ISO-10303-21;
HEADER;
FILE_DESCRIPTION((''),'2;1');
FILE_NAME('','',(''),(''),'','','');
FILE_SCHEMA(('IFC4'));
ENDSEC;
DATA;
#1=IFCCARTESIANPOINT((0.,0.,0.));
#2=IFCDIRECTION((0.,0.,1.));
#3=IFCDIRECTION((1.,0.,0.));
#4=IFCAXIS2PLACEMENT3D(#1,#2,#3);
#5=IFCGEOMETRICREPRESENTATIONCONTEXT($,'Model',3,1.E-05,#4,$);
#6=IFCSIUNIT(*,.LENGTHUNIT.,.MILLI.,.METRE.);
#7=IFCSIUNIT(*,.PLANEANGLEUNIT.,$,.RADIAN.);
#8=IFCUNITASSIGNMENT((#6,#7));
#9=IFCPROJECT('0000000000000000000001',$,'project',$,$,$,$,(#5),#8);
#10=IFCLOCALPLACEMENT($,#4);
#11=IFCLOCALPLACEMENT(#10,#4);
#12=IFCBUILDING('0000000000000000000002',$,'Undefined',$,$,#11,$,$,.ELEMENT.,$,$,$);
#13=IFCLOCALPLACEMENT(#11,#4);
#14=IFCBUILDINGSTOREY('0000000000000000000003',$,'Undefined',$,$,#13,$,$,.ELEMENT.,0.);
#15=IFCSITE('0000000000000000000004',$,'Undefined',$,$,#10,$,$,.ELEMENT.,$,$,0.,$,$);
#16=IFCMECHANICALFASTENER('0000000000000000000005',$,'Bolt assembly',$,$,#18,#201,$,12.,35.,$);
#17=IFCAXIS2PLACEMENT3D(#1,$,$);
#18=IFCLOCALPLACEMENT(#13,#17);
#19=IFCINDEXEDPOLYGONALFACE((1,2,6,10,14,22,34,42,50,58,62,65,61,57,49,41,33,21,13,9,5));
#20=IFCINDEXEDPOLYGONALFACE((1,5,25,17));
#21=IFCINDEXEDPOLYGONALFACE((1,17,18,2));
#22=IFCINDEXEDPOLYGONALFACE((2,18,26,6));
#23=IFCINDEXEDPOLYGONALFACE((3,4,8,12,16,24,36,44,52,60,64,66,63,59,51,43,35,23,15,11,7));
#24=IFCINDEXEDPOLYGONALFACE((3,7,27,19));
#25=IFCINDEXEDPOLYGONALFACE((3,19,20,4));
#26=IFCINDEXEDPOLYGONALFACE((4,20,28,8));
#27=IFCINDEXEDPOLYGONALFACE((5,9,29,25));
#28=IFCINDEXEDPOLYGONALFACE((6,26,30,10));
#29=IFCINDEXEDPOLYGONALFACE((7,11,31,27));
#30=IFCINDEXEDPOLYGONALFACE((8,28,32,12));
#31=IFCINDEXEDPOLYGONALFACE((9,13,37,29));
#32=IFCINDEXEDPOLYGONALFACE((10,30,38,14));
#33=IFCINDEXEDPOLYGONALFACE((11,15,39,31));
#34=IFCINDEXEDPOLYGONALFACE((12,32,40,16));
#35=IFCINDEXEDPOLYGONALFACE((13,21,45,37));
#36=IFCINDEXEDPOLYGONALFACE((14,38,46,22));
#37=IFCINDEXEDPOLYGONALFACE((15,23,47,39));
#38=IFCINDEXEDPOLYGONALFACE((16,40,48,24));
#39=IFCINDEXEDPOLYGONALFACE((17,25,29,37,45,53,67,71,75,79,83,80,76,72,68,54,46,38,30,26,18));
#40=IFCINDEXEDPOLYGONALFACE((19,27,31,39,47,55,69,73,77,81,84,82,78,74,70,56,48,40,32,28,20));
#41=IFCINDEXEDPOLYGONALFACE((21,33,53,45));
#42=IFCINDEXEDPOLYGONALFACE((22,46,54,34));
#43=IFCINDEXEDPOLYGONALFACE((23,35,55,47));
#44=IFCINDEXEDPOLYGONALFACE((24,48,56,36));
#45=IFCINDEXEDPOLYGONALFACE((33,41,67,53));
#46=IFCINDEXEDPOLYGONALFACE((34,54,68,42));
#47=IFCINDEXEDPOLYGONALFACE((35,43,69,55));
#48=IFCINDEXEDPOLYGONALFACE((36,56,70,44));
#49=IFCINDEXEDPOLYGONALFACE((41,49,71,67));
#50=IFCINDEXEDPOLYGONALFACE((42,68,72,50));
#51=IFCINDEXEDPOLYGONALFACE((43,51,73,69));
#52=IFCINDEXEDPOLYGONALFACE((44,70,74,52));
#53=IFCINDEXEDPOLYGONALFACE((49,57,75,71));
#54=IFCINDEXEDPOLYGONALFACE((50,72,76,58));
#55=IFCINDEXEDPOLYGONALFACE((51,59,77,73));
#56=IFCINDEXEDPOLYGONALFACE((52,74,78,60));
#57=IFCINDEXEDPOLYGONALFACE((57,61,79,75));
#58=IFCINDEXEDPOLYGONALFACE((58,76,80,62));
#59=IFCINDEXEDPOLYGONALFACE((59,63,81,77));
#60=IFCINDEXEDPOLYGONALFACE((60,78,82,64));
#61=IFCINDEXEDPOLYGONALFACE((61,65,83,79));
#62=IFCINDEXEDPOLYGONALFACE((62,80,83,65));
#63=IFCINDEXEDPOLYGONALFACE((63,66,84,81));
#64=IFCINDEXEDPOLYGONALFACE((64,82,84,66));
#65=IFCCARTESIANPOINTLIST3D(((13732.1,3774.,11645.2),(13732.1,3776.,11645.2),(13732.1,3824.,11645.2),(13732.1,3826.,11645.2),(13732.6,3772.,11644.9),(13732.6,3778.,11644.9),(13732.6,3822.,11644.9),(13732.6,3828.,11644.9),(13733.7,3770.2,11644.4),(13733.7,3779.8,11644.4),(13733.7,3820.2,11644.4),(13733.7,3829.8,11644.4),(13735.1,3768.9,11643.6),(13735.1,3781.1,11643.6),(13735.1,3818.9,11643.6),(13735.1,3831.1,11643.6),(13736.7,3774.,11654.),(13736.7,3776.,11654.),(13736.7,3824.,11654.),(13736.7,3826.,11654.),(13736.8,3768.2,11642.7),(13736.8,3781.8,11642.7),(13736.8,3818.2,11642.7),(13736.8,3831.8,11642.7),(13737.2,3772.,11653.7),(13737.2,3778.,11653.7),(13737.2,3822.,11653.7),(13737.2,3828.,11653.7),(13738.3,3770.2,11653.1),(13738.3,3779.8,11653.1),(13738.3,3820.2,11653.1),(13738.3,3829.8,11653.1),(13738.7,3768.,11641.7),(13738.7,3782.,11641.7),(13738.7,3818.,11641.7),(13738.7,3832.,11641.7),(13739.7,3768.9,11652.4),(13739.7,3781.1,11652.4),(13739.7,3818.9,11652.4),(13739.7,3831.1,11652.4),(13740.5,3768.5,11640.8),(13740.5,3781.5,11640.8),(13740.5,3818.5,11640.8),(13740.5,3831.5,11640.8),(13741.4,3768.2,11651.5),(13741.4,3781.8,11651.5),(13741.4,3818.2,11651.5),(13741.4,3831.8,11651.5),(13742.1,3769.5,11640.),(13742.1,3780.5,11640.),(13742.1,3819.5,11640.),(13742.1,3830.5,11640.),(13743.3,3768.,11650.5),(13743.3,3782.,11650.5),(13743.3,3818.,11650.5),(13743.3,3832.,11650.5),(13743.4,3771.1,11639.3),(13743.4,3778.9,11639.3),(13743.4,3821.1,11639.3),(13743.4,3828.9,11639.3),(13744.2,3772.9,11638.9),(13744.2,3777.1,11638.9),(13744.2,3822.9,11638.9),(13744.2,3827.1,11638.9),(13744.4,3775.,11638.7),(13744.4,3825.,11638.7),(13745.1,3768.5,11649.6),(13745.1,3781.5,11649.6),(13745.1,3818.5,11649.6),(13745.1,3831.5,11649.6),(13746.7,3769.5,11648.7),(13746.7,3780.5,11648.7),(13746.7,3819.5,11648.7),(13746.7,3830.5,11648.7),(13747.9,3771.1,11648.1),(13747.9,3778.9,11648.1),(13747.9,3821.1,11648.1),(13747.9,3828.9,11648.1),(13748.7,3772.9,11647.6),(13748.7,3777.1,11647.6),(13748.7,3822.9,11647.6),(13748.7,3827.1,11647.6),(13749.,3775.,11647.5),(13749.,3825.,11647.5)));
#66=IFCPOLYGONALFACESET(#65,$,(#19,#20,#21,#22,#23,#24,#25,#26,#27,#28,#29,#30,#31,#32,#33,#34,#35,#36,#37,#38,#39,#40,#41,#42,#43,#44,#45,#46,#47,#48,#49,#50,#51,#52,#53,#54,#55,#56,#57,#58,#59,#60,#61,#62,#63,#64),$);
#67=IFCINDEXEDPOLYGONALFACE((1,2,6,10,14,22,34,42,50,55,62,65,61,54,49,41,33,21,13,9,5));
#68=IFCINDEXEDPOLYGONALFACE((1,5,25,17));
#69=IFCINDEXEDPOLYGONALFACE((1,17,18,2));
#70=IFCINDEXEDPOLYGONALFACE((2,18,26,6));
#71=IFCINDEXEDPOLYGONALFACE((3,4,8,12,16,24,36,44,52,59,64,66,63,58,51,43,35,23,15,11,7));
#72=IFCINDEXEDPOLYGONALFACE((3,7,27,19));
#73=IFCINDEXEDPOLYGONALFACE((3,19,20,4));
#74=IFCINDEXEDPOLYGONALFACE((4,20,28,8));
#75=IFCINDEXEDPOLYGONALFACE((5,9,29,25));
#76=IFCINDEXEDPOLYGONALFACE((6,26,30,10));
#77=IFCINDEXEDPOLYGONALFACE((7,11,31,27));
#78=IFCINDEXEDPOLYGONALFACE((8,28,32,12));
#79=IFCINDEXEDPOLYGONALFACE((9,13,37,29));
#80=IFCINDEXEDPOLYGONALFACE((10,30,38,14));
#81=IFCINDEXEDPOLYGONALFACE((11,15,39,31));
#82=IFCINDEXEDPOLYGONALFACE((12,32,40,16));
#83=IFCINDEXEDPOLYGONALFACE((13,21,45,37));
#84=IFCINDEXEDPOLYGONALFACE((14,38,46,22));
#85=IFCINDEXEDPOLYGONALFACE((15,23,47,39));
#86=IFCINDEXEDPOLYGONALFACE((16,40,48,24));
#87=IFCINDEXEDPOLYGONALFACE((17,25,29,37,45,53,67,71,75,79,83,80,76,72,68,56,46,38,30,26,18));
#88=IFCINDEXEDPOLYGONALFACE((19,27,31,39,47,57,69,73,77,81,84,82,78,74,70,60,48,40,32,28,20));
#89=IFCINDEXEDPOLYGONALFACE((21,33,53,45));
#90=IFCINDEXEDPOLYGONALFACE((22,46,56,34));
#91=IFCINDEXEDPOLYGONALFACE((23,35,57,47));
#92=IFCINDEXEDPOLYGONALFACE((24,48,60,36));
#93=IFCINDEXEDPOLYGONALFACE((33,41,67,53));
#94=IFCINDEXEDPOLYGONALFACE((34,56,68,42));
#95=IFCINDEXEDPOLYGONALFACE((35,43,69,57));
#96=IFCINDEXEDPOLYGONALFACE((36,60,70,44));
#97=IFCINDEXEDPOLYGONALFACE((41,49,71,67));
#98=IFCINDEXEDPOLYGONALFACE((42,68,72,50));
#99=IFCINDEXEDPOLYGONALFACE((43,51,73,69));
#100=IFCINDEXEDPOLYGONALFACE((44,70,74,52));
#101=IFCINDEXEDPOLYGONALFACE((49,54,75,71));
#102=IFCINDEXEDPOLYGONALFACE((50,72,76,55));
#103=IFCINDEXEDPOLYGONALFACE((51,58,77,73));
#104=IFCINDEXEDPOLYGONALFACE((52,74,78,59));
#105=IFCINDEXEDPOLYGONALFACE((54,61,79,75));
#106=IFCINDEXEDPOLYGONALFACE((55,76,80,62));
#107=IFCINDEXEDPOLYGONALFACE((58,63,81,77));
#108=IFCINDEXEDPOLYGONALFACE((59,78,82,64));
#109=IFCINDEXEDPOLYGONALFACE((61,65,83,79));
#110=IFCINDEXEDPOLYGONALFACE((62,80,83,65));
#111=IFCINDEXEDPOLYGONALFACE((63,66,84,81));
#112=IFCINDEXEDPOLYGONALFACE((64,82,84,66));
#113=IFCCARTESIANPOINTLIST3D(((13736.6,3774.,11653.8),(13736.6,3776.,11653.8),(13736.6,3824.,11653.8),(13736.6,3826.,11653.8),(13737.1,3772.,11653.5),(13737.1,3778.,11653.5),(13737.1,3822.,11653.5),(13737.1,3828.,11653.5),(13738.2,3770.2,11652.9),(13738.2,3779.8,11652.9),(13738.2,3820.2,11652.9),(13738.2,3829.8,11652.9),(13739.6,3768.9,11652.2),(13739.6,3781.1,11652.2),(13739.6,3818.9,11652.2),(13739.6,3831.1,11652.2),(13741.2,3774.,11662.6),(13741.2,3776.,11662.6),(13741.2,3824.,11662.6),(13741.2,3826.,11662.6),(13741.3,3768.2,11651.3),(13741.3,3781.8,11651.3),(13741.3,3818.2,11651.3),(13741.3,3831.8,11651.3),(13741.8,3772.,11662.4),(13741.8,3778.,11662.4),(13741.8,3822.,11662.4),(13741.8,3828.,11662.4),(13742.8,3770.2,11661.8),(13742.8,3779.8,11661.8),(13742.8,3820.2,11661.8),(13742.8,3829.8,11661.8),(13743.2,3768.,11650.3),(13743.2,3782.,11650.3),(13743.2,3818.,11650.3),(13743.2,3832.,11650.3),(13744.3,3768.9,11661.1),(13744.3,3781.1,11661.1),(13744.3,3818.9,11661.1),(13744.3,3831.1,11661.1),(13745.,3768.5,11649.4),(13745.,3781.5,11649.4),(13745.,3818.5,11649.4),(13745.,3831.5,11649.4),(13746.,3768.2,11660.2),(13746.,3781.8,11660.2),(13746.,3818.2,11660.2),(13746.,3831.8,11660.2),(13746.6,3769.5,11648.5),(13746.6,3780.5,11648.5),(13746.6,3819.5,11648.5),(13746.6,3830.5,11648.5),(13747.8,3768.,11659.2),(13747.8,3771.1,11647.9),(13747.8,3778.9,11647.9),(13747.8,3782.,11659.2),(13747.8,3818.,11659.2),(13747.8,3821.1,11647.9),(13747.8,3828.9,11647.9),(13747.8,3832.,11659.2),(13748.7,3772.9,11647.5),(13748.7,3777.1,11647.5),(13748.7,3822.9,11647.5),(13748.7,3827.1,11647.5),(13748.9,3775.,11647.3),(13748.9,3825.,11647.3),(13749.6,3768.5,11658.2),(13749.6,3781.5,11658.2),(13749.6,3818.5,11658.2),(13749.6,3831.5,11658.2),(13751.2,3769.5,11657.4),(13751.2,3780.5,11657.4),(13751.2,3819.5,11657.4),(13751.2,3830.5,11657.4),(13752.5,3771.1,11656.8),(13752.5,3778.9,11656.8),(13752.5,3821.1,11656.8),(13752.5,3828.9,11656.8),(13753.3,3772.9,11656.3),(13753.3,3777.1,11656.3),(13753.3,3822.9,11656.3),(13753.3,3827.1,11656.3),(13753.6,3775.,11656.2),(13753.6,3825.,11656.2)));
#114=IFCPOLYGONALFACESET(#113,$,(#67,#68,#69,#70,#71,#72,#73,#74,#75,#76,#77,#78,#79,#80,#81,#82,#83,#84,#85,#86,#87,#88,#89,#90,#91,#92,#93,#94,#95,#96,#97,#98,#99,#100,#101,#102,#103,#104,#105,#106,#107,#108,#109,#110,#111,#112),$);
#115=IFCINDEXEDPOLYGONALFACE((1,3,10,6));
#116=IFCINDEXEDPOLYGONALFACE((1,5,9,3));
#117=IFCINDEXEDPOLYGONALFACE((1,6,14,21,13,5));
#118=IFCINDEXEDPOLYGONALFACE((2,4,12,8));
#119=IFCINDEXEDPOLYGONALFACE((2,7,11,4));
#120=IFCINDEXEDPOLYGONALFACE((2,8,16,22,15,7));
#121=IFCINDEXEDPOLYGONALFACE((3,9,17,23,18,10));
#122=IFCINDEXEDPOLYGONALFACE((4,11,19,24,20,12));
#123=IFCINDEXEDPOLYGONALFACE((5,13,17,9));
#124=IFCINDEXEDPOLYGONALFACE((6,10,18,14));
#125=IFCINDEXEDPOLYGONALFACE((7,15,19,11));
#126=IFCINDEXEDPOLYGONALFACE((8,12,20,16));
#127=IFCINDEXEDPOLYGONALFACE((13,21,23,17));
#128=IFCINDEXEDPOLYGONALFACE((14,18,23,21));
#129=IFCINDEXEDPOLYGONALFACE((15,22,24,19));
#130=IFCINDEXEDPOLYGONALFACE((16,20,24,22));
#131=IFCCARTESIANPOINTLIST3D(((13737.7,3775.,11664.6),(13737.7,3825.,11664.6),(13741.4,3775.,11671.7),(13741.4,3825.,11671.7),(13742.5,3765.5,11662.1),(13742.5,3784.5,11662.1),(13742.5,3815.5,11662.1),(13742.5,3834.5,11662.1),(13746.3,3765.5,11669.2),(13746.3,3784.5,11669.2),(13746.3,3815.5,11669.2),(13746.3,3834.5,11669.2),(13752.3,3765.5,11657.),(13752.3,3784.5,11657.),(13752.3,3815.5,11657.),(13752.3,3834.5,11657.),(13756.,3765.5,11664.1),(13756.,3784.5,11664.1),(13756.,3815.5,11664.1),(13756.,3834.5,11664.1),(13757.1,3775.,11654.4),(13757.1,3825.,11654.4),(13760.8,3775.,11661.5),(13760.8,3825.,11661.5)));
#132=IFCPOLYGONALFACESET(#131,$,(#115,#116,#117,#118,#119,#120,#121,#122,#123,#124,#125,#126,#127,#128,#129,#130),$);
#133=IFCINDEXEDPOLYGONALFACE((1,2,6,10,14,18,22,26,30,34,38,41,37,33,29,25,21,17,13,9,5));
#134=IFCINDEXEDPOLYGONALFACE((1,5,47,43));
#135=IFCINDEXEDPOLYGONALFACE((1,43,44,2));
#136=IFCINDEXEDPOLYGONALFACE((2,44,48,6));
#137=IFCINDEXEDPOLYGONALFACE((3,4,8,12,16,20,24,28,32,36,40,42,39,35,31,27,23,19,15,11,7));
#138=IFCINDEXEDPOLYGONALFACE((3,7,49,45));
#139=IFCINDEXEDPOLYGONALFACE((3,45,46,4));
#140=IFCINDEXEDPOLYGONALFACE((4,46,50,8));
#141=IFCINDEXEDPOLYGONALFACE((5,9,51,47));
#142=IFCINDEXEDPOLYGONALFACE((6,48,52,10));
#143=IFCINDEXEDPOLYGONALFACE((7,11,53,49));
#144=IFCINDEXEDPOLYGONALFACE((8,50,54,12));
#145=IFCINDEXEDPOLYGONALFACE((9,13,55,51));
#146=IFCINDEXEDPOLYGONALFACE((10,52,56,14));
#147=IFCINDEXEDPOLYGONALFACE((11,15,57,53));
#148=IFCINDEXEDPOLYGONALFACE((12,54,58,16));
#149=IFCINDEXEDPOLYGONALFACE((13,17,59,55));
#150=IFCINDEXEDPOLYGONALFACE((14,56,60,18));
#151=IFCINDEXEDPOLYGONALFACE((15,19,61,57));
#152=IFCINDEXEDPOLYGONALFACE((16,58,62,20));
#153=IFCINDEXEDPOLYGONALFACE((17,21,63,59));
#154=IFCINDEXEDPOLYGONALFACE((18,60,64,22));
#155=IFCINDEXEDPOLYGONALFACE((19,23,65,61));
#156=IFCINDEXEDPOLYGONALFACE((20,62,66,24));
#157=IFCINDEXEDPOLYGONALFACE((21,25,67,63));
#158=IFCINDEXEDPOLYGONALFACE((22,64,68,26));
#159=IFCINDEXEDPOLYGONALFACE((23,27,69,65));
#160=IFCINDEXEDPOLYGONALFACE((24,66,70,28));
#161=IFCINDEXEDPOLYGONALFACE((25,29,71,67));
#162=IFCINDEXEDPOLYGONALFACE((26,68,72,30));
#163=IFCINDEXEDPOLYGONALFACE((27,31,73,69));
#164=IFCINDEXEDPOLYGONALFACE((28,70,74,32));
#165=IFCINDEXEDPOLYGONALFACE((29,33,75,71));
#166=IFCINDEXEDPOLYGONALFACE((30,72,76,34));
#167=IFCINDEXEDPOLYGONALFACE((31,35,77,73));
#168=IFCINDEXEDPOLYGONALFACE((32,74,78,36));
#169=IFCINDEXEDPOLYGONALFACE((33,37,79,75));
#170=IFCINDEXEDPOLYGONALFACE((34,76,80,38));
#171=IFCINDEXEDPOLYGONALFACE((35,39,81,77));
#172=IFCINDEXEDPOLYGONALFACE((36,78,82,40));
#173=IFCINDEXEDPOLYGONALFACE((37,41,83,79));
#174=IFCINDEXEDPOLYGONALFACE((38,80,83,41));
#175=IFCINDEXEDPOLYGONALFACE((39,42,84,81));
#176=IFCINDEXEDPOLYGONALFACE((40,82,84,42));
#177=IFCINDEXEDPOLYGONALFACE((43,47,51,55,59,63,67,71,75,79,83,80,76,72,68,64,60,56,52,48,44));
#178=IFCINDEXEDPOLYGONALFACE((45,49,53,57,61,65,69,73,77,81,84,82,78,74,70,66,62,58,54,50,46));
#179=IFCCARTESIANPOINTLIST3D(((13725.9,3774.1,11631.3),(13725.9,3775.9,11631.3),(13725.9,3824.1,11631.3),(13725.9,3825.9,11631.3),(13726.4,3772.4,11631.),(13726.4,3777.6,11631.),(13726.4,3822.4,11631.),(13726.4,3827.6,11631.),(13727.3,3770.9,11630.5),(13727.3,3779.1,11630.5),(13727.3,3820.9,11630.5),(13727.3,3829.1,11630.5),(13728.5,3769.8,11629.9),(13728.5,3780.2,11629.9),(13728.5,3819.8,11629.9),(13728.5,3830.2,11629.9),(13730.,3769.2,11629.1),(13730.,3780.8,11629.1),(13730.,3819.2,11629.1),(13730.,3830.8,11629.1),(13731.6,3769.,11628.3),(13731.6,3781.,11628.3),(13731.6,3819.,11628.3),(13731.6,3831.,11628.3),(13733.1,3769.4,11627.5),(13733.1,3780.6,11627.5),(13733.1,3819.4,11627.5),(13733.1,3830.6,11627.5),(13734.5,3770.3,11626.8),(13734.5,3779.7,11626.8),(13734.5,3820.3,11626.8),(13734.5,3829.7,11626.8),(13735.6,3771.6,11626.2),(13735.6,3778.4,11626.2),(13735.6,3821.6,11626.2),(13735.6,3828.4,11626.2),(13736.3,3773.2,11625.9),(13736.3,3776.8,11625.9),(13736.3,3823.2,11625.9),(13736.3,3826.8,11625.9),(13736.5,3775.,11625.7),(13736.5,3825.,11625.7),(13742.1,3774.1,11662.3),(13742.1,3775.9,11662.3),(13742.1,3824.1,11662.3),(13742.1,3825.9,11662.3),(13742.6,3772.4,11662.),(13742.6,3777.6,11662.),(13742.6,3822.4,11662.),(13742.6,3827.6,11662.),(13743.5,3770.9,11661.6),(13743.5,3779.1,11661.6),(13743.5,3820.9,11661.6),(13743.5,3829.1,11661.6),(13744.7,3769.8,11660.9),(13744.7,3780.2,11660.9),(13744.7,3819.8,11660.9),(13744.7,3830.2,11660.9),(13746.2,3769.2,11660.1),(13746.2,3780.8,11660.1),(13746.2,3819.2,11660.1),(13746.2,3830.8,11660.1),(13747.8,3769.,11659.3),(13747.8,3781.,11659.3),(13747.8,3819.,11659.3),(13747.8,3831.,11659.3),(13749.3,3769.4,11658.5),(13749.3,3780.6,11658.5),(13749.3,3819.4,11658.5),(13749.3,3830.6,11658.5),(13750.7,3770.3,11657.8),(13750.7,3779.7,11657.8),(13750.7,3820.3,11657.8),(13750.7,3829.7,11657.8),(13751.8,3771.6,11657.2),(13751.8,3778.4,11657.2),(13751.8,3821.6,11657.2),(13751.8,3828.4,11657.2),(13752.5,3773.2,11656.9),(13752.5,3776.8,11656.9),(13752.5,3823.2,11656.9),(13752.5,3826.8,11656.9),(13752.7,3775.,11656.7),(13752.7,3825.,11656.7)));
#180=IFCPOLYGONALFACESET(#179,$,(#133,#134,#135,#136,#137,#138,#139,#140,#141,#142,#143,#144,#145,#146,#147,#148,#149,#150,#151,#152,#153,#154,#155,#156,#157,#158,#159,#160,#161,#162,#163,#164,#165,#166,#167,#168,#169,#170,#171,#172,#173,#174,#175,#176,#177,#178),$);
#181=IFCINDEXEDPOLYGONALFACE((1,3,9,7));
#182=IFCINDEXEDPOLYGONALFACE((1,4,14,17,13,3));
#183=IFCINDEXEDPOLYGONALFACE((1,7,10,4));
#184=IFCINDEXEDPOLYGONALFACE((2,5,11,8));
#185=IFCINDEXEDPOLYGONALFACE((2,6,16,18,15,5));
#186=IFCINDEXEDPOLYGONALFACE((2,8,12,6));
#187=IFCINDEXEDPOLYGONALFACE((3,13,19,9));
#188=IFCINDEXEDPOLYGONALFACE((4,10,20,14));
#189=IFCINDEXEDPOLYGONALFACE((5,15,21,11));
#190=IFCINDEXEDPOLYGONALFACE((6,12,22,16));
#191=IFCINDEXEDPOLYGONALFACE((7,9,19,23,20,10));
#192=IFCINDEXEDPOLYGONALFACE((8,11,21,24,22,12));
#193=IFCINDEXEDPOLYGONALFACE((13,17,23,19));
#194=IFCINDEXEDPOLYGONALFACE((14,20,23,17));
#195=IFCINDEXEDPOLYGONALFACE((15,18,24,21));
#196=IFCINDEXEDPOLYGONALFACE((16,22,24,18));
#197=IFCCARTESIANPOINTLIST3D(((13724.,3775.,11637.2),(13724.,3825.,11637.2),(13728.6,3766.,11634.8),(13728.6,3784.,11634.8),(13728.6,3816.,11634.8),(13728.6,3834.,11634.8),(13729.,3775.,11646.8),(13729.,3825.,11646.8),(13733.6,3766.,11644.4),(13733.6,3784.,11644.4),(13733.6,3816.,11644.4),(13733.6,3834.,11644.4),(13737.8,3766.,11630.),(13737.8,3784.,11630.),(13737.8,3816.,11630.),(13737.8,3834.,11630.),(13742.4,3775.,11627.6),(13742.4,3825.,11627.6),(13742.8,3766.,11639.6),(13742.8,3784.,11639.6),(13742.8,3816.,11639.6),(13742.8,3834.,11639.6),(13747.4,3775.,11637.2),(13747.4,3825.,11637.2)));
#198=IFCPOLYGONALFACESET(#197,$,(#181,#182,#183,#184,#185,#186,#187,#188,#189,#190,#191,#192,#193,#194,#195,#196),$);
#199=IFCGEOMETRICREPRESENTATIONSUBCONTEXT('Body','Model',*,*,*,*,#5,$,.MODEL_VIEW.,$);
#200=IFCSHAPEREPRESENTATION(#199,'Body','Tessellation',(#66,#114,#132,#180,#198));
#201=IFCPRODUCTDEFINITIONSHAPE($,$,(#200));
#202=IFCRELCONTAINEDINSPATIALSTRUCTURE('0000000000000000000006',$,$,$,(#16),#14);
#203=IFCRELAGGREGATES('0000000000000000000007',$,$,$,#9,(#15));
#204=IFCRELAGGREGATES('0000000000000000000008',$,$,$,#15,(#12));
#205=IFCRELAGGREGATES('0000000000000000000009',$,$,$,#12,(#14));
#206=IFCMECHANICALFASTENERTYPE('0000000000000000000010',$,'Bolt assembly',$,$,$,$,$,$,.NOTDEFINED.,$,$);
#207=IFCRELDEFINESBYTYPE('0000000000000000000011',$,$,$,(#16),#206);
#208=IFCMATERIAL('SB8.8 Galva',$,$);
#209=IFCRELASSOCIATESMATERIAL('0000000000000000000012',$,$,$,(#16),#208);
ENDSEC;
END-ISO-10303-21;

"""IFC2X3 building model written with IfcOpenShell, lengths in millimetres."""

from ifc_helpers import new_model, si_unit, frame, origin_with_axes, origin_2d_with_axis, place, context, subcontext, project, spatial, polyline, circle, outline, extrude, source, transform, mapped, material, type_object, element, save


model = new_model("IFC2X3")

# Units and contexts
model_context = context("Model", 3, precision=1e-05, world=origin_with_axes())
body_context = subcontext(model_context, "Body", "Model", "MODEL_VIEW")
ifc_project = project(units=[si_unit("LENGTHUNIT", "METRE", prefix="MILLI"), si_unit("PLANEANGLEUNIT", "RADIAN")], contexts=[model_context])

# Site, building, storey
site_placement = place(None, origin_with_axes())
site = spatial("IfcSite", under=ifc_project, at=site_placement, Name="Undefined", CompositionType="ELEMENT", RefElevation=0.0)
building_placement = place(site_placement, origin_with_axes())
building = spatial("IfcBuilding", under=site, at=building_placement, Name="Undefined", CompositionType="ELEMENT")
storey_placement = place(building_placement, origin_with_axes())
storey = spatial("IfcBuildingStorey", under=building, at=storey_placement, Name="Undefined", CompositionType="ELEMENT", Elevation=0.0)

# Mechanical fastener
ifc_material_1 = material(Name="SB8.8 Galva")
mechanical_fastener_type = type_object("IfcMechanicalFastenerType", Name="Bolt assembly")
shared_shape_1 = source(origin_with_axes(), body_context, "Body", "SweptSolid", [
    extrude(circle(Radius=7.0, at=origin_2d_with_axis()), frame((0.0, -0.1, 0.0), z_axis=(0.0, 1.0, 0.0), x_axis=(1.0, 0.0, 0.0)), (0.0, 0.0, 1.0), 9.9),
    extrude(circle(Radius=7.0, at=origin_2d_with_axis()), frame((0.0, -9.9, 0.0), z_axis=(0.0, 1.0, 0.0), x_axis=(1.0, 0.0, 0.0)), (0.0, 0.0, 1.0), 10.0),
    extrude(outline(polyline([(11.0, 0.0), (5.5, 9.5), (-5.5, 9.5), (-11.0, 0.0), (-5.5, -9.5), (5.5, -9.5), (11.0, 0.0)])), frame((0.0, -18.0, 0.0), z_axis=(0.0, 1.0, 0.0), x_axis=(1.0, 0.0, 0.0)), (0.0, 0.0, 1.0), 8.0),
    extrude(circle(Radius=6.0, at=origin_2d_with_axis()), frame((0.0, -10.0, 0.0), z_axis=(0.0, 1.0, 0.0), x_axis=(1.0, 0.0, 0.0)), (0.0, 0.0, 1.0), 35.0),
    extrude(outline(polyline([(10.4, 0.0), (5.2, 9.0), (-5.2, 9.0), (-10.4, 0.0), (-5.2, -9.0), (5.2, -9.0), (10.4, 0.0)])), frame((0.0, 9.8, 0.0), z_axis=(0.0, 1.0, 0.0), x_axis=(1.0, 0.0, 0.0)), (0.0, 0.0, 1.0), 10.8),
])
for number, where, z_axis, x_axis, name in (
    (1, (13742.8, 3800.0, 11650.7), (0.0, 1.0, 0.0), (0.886082, 0.0, -0.463529), "Bolt assembly"),
):
    element("IfcMechanicalFastener", number, at=place(storey_placement, frame(where, z_axis=z_axis, x_axis=x_axis)), inside=storey, type_object=mechanical_fastener_type, material=ifc_material_1, Name=name, NominalDiameter=12.0, NominalLength=35.0, context=body_context, shape_type="MappedRepresentation", body=[
        mapped(shared_shape_1, transform((0.0, 0.0, -25.0))),
        mapped(shared_shape_1, transform((0.0, 0.0, 25.0))),
    ])

save(model, "model.ifc")
